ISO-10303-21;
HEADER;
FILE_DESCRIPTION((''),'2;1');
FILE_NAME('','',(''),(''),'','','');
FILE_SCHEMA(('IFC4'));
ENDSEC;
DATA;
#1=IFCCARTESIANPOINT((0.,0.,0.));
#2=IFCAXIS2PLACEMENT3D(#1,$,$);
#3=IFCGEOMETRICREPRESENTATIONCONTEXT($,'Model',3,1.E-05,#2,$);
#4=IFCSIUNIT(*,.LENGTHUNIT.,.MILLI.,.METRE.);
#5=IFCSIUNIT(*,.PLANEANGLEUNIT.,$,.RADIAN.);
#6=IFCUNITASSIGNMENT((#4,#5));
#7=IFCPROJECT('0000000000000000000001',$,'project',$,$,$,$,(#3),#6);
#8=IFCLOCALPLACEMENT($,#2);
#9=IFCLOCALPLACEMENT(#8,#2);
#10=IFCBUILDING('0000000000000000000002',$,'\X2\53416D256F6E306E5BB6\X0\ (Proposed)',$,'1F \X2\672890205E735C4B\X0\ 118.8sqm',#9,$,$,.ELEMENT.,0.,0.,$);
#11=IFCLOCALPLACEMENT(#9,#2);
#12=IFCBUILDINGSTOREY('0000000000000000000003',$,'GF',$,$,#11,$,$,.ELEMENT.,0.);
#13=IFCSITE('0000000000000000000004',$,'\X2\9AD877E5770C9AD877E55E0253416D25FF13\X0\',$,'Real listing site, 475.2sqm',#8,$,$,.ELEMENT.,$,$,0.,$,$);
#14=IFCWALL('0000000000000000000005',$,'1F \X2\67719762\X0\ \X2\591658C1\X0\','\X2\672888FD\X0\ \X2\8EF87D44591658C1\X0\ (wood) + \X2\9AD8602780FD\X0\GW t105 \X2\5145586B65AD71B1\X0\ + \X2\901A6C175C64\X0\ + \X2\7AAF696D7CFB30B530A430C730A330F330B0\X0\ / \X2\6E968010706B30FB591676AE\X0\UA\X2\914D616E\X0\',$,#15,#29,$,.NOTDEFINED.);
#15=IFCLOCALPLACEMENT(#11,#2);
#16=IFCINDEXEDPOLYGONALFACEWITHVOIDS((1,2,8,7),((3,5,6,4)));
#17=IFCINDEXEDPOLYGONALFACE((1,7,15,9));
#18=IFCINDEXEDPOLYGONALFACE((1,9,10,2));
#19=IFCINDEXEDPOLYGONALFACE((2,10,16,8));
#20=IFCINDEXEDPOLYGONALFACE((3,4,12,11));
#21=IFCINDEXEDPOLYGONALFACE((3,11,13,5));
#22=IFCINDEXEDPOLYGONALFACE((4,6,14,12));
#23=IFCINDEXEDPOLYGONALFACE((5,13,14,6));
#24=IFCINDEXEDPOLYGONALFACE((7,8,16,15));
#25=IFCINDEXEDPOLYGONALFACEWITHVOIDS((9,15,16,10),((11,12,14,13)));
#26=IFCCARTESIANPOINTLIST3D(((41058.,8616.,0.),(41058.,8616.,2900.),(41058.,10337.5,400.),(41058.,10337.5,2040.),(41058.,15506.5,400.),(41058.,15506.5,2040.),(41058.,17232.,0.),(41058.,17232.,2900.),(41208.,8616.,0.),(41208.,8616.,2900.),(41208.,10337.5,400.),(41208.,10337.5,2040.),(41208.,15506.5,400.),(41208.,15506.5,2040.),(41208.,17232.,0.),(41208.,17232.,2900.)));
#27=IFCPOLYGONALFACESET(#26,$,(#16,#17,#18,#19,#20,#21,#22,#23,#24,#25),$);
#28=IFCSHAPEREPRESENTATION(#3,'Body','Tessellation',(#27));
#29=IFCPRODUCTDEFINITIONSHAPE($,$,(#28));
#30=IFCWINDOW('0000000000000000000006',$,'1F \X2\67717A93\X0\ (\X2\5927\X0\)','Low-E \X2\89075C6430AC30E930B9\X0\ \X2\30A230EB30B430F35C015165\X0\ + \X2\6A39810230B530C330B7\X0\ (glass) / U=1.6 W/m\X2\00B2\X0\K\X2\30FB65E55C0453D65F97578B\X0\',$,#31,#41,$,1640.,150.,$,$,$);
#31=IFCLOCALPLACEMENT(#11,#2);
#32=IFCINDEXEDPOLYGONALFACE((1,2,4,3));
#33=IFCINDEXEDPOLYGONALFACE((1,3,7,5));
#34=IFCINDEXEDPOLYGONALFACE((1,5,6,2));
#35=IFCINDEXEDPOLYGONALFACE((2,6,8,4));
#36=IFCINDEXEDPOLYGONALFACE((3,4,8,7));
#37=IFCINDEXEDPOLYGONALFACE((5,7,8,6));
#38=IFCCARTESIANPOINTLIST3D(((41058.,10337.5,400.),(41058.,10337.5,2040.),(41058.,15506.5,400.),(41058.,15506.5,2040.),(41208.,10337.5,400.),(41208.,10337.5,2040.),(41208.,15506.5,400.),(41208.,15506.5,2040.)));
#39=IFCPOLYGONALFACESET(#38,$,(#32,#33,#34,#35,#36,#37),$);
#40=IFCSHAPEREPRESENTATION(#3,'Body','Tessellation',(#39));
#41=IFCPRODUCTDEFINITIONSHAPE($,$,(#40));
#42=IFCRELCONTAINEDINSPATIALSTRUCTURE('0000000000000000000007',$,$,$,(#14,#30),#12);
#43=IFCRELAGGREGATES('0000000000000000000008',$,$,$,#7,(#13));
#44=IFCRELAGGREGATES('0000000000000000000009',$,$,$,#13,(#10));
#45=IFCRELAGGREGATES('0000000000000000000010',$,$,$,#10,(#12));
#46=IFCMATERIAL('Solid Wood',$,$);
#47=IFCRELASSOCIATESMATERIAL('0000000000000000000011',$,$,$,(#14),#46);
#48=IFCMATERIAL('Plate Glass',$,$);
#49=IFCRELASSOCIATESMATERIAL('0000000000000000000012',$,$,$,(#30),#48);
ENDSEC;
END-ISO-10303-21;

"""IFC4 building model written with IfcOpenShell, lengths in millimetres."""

from ifc_helpers import new_model, si_unit, frame, frame_2d, origin, place, context, project, spatial, rectangle, extrude, material, element, fill, save


model = new_model("IFC4")

# Units and contexts
model_context = context("Model", 3, precision=1e-05, world=origin())
ifc_project = project(units=[si_unit("LENGTHUNIT", "METRE", prefix="MILLI"), si_unit("PLANEANGLEUNIT", "RADIAN")], contexts=[model_context])

# Site, building, storey
site_placement = place(None, origin())
site = spatial("IfcSite", under=ifc_project, at=site_placement, Name="高知県高知市十津３", ObjectType="Real listing site, 475.2sqm", CompositionType="ELEMENT", RefElevation=0.0)
building_placement = place(site_placement, origin())
building = spatial("IfcBuilding", under=site, at=building_placement, Name="十津潮の家 (Proposed)", ObjectType="1F 木造平屋 118.8sqm", CompositionType="ELEMENT", ElevationOfRefHeight=0.0, ElevationOfTerrain=0.0)
storey_placement = place(building_placement, origin())
storey = spatial("IfcBuildingStorey", under=building, at=storey_placement, Name="GF", CompositionType="ELEMENT", Elevation=0.0)

# Wall, opening, window
ifc_material_1 = material(Name="Solid Wood")
wall_1_placement = place(storey_placement, frame((20529.0, 4308.0, 0.0)))
wall_1 = element("IfcWall", 1, at=wall_1_placement, inside=storey, material=ifc_material_1, Name="1F 東面 外壁", Description="木製 軸組外壁 (wood) + 高性能GW t105 充填断熱 + 通気層 + 窯業系サイディング / 準耐火・外皮UA配慮", PredefinedType="NOTDEFINED", context=model_context, shape_type="SweptSolid", body=[
    extrude(rectangle(XDim=150.0, YDim=8616.0, at=frame_2d((75.0, 4308.0))), frame((20529.0, 4308.0, 0.0)), (0.0, 0.0, 1.0), 2900.0),
])
opening_placement = place(storey_placement, frame((20529.0, 5169.0, 200.0)))
opening = element("IfcOpeningElement", 2, at=opening_placement, cuts=wall_1, PredefinedType="NOTDEFINED", context=model_context, shape_type="SweptSolid", body=[
    extrude(rectangle(XDim=150.0, YDim=5169.0, at=frame_2d((75.0, 2584.0))), frame((20529.0, 5169.0, 200.0)), (0.0, 0.0, 1.0), 1640.0),
])
ifc_material_2 = material(Name="Plate Glass")
window_1_placement = place(storey_placement, frame((20529.0, 5169.0, 200.0)))
window_1 = element("IfcWindow", 3, at=window_1_placement, inside=storey, material=ifc_material_2, Name="1F 東窓 (大)", Description="Low-E 複層ガラス アルゴン封入 + 樹脂サッシ (glass) / U=1.6 W/m²K・日射取得型", OverallHeight=1640.0, OverallWidth=150.0, context=model_context, shape_type="SweptSolid", body=[
    extrude(rectangle(XDim=150.0, YDim=5169.0, at=frame_2d((75.0, 2584.0))), frame((20529.0, 5169.0, 200.0)), (0.0, 0.0, 1.0), 1640.0),
])
fill(opening, window_1)

save(model, "model.ifc")
